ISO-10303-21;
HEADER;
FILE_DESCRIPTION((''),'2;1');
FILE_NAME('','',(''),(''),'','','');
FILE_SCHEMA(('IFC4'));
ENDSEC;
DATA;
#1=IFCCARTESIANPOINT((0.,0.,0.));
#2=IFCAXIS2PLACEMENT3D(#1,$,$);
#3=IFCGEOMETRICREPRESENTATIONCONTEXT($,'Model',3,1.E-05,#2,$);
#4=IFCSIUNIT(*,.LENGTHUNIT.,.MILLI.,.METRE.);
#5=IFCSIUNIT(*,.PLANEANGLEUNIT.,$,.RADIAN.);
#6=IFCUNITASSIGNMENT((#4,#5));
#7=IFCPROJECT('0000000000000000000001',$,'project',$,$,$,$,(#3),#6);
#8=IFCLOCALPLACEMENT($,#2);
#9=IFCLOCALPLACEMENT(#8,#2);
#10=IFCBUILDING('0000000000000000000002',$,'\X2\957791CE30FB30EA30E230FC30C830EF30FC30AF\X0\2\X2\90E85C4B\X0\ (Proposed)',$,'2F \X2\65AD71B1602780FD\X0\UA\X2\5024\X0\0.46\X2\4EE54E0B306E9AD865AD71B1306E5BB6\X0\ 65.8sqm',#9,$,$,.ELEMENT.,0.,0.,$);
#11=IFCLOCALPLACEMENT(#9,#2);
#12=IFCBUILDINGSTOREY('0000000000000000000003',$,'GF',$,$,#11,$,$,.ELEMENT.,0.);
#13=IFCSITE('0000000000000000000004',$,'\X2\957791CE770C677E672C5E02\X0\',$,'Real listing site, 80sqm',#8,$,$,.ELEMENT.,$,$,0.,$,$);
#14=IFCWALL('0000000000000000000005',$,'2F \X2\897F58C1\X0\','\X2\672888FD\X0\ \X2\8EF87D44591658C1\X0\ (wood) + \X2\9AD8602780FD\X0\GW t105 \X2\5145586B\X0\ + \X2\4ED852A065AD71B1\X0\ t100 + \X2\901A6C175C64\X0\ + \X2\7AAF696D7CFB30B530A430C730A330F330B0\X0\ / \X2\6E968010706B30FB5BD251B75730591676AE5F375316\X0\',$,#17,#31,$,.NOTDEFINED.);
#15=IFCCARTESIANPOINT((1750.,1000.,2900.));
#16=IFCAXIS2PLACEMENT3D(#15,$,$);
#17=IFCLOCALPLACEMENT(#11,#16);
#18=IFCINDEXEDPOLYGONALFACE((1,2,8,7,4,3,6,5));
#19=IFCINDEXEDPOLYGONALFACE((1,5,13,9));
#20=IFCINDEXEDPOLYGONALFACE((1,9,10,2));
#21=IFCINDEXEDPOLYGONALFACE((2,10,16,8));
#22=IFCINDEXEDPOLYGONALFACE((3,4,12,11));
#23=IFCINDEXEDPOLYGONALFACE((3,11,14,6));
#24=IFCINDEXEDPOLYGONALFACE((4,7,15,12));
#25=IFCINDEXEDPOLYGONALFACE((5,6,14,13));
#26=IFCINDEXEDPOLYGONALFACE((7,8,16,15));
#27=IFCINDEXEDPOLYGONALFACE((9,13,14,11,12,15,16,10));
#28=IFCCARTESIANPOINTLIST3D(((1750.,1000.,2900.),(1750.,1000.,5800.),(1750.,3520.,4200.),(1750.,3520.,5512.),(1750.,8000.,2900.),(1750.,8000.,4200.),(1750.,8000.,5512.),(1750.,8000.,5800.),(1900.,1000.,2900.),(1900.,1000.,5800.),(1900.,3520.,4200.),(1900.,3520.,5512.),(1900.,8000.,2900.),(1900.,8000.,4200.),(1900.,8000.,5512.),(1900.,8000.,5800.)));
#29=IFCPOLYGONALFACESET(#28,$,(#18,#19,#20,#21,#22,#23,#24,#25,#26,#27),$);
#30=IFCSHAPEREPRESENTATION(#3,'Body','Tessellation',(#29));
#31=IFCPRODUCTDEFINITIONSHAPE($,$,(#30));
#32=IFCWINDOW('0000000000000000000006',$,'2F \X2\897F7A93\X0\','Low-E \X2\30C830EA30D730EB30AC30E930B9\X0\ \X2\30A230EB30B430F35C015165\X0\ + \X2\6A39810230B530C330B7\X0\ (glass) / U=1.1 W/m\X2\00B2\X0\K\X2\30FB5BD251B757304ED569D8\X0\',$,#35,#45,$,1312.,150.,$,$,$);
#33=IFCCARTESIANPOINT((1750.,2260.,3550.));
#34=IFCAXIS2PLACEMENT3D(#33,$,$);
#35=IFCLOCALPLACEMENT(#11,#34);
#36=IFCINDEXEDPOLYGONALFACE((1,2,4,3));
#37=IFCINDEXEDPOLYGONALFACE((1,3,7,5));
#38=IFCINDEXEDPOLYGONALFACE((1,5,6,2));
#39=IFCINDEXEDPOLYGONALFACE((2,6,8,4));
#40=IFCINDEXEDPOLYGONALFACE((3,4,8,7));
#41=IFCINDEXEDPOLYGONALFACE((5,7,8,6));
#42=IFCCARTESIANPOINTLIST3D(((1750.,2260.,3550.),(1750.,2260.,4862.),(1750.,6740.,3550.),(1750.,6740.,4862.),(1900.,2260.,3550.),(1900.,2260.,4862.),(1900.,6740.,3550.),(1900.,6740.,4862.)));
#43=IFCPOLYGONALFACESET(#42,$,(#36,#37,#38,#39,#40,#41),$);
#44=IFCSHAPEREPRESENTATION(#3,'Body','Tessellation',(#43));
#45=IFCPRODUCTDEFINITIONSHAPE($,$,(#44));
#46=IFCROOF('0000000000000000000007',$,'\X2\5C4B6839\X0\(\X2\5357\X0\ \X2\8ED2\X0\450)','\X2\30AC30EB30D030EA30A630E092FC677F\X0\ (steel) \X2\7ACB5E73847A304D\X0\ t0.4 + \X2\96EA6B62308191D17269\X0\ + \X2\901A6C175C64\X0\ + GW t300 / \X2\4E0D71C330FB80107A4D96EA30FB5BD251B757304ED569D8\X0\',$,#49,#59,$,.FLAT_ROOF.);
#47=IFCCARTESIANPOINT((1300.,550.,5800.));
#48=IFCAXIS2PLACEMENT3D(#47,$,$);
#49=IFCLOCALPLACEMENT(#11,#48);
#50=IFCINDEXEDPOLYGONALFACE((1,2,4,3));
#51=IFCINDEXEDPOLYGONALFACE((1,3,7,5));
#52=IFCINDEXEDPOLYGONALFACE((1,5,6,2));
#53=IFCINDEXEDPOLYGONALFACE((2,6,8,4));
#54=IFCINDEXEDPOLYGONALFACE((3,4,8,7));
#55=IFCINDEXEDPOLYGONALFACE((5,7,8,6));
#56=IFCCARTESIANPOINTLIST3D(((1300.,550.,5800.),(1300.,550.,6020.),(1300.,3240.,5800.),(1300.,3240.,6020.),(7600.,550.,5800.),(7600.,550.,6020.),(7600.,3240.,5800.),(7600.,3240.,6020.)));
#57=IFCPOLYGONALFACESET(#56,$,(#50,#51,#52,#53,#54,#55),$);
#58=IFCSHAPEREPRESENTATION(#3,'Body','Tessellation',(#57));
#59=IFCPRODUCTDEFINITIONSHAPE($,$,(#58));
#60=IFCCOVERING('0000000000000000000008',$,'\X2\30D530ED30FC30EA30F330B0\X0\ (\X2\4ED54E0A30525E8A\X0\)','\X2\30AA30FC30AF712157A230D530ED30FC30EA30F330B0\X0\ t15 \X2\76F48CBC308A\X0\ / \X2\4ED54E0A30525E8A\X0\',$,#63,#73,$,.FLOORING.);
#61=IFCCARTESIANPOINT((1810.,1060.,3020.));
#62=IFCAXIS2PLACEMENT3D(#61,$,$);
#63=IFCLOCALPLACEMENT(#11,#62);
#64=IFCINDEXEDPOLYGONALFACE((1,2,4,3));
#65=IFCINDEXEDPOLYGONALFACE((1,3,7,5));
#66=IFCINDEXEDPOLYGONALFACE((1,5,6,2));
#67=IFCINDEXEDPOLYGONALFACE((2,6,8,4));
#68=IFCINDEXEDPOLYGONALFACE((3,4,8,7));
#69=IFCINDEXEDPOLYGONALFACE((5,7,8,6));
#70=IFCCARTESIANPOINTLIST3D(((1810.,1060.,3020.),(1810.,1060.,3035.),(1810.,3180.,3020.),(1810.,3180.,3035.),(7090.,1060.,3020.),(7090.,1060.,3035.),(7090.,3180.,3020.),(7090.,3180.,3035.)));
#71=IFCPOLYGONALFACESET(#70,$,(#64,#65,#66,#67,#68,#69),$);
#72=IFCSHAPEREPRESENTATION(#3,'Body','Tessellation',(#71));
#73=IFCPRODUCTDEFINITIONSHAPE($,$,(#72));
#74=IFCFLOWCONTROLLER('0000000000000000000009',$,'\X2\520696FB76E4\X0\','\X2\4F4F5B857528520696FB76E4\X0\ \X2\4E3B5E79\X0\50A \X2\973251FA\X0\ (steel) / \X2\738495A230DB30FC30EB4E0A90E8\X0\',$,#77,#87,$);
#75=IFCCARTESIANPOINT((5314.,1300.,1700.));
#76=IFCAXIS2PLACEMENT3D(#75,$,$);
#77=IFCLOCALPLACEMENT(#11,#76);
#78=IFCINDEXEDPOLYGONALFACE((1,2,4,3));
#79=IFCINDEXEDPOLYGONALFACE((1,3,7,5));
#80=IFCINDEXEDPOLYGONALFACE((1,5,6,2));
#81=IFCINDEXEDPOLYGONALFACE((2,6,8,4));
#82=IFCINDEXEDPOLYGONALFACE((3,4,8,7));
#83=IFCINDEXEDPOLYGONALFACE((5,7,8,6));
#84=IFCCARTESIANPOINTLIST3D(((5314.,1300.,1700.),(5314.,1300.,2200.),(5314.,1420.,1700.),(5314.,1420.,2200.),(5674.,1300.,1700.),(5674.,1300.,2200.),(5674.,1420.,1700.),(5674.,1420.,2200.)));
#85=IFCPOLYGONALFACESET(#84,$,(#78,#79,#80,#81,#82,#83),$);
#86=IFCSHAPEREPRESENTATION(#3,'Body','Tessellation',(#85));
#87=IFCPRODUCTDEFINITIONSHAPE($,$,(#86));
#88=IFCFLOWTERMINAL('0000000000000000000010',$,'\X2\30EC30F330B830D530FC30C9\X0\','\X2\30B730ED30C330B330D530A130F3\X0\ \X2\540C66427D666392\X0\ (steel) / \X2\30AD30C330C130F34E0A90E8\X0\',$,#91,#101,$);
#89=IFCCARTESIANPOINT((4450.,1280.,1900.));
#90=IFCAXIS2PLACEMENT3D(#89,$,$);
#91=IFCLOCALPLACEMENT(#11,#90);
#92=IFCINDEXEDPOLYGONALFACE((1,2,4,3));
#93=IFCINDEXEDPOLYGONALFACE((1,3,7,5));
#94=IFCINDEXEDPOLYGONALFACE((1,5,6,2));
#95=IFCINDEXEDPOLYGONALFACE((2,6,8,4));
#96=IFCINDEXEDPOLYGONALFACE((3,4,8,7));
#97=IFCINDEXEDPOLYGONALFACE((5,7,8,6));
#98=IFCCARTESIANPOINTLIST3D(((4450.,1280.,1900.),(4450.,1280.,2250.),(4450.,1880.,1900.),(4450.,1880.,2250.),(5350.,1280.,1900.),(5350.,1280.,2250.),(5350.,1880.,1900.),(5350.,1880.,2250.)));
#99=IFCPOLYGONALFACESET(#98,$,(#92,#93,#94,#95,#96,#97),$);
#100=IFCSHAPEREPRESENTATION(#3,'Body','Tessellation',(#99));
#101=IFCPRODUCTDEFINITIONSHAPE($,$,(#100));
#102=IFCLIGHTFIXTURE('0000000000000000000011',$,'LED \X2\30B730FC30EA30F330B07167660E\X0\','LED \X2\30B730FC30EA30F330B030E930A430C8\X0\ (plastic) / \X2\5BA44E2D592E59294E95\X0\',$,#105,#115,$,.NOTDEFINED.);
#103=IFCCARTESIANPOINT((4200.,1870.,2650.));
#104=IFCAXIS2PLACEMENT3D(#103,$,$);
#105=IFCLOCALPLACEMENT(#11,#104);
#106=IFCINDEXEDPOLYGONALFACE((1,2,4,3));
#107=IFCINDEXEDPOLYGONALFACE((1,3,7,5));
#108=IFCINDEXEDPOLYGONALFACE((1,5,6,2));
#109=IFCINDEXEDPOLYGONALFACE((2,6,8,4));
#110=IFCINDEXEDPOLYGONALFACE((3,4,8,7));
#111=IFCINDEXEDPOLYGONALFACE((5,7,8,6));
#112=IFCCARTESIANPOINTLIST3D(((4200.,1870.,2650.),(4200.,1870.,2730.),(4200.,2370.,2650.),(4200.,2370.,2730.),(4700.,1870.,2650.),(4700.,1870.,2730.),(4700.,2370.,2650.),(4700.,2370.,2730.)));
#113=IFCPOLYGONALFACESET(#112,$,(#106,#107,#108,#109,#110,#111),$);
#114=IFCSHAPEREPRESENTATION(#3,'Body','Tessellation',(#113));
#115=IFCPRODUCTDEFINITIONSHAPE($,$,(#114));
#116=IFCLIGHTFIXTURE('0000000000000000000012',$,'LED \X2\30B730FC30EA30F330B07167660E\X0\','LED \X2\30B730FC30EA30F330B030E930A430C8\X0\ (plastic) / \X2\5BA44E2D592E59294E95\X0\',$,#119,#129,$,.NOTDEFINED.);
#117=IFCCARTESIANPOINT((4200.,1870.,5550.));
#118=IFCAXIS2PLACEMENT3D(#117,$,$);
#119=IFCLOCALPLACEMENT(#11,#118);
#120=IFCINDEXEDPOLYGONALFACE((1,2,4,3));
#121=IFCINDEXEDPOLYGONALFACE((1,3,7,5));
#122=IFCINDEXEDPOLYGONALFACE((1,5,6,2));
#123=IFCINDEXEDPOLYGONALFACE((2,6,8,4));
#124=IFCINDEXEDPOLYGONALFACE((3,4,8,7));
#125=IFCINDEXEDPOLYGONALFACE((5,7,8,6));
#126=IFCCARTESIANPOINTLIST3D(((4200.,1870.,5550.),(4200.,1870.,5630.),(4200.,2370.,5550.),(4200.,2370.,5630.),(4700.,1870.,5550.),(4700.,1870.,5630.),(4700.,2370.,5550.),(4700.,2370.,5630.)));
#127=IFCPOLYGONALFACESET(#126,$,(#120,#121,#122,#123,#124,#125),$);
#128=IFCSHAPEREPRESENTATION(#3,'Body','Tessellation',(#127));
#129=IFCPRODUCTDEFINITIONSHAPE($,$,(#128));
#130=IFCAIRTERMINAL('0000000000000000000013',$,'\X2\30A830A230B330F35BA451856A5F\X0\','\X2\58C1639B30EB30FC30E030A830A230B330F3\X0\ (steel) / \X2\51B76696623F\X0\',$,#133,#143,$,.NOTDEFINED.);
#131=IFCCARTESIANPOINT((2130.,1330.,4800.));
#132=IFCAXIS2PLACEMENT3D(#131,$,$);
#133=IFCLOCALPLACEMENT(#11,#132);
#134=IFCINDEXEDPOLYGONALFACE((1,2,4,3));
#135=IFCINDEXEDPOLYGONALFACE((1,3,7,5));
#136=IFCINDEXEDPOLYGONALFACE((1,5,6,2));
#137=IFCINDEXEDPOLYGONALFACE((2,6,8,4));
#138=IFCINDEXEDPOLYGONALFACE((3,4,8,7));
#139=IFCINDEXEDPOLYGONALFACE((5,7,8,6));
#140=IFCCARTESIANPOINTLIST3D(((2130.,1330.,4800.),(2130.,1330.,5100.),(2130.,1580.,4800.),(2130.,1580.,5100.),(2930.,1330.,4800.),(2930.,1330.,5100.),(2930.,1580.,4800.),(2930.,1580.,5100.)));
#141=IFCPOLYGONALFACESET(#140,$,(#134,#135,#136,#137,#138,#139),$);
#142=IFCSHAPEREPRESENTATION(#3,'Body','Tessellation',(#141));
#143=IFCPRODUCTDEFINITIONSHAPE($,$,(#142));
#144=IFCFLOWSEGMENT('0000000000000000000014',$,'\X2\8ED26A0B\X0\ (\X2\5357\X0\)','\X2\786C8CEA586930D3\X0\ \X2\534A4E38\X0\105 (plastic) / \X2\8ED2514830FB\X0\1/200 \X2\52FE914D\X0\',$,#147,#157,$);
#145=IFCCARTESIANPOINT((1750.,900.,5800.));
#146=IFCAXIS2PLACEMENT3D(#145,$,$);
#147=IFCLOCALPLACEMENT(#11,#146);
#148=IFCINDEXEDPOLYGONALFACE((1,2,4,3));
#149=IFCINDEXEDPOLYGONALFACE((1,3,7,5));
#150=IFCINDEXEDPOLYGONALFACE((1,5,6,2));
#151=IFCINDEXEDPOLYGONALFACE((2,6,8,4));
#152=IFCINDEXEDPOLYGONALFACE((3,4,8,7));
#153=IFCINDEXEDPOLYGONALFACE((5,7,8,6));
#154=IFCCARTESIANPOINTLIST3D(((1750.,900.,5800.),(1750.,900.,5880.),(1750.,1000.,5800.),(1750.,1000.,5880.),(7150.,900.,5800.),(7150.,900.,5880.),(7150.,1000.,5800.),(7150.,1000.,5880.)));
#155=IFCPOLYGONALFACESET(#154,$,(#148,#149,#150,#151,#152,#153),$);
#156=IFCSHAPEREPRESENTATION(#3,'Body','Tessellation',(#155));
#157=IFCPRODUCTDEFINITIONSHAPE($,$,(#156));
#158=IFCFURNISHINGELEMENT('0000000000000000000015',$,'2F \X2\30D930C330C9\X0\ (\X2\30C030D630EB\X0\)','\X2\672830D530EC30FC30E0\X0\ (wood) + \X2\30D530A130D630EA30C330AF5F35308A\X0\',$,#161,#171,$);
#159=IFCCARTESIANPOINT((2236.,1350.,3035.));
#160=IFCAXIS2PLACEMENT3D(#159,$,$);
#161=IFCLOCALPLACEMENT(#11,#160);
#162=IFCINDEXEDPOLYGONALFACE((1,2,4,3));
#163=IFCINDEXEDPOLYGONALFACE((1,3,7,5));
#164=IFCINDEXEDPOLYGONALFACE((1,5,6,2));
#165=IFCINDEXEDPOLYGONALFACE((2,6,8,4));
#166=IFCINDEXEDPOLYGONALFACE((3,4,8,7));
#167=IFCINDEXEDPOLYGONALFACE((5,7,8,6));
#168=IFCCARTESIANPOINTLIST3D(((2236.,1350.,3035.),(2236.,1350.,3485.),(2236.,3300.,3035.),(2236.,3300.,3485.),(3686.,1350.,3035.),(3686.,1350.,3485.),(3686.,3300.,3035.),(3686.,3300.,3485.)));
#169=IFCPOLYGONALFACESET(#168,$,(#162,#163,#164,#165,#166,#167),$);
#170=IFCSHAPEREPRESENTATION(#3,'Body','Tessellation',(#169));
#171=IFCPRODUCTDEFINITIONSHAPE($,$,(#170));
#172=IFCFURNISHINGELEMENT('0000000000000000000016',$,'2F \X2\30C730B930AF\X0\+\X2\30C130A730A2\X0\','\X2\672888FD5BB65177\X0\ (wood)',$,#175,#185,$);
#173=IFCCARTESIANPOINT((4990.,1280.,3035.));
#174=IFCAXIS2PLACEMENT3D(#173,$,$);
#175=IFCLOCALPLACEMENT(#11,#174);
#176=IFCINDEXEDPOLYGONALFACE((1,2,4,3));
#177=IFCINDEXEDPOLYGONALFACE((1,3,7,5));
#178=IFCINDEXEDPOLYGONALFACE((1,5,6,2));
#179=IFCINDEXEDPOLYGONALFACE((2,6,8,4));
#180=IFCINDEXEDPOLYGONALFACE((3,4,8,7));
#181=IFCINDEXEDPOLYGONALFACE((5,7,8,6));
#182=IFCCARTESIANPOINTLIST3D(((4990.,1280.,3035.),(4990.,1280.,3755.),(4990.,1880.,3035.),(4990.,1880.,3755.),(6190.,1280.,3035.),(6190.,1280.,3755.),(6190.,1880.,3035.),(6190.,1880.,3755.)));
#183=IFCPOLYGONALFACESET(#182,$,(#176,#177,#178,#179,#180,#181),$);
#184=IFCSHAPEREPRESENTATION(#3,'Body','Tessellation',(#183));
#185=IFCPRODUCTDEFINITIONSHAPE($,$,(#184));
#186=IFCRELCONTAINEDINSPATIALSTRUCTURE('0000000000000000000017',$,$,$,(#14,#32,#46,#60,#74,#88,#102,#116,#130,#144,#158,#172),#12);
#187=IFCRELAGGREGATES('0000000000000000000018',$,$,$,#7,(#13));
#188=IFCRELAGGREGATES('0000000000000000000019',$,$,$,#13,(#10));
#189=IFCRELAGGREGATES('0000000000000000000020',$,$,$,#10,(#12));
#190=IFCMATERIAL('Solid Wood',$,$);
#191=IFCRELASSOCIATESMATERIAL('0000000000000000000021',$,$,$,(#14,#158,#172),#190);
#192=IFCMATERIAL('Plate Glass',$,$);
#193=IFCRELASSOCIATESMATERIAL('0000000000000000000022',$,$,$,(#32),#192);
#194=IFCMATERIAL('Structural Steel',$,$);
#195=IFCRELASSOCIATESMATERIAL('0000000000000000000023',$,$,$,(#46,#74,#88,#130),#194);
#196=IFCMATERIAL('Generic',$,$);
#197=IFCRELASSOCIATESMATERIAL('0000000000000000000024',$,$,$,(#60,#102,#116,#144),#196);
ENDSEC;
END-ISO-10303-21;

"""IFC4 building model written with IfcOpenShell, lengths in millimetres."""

from ifc_helpers import new_model, si_unit, frame, frame_2d, origin, place, context, project, spatial, rectangle, extrude, material, element, fill, save


model = new_model("IFC4")

# Units and contexts
model_context = context("Model", 3, precision=1e-05, world=origin())
ifc_project = project(units=[si_unit("LENGTHUNIT", "METRE", prefix="MILLI"), si_unit("PLANEANGLEUNIT", "RADIAN")], contexts=[model_context])

# Site, building, storey
site_placement = place(None, origin())
site = spatial("IfcSite", under=ifc_project, at=site_placement, Name="長野県松本市", ObjectType="Real listing site, 80sqm", CompositionType="ELEMENT", RefElevation=0.0)
building_placement = place(site_placement, origin())
building = spatial("IfcBuilding", under=site, at=building_placement, Name="長野・リモートワーク2部屋 (Proposed)", ObjectType="2F 断熱性能UA値0.46以下の高断熱の家 65.8sqm", CompositionType="ELEMENT", ElevationOfRefHeight=0.0, ElevationOfTerrain=0.0)
storey_placement = place(building_placement, origin())
storey = spatial("IfcBuildingStorey", under=building, at=storey_placement, Name="GF", CompositionType="ELEMENT", Elevation=0.0)

# Shared definitions
ifc_material_1 = material(Name="Solid Wood")

# Wall, opening, window
ifc_material_2 = material(Name="Plate Glass")
wall_1_placement = place(storey_placement, frame((1750.0, 1000.0, 2900.0)))
wall_1 = element("IfcWall", 1, at=wall_1_placement, inside=storey, material=ifc_material_1, Name="2F 西壁", Description="木製 軸組外壁 (wood) + 高性能GW t105 充填 + 付加断熱 t100 + 通気層 + 窯業系サイディング / 準耐火・寒冷地外皮強化", PredefinedType="NOTDEFINED", context=model_context, shape_type="SweptSolid", body=[
    extrude(rectangle(XDim=150.0, YDim=7000.0, at=frame_2d((75.0, 3500.0))), frame((1750.0, 1000.0, 2900.0)), (0.0, 0.0, 1.0), 2900.0),
])
opening_1_placement = place(storey_placement, frame((1750.0, 2260.0, 3550.0)))
opening_1 = element("IfcOpeningElement", 2, at=opening_1_placement, cuts=wall_1, PredefinedType="NOTDEFINED", context=model_context, shape_type="SweptSolid", body=[
    extrude(rectangle(XDim=150.0, YDim=4480.0, at=frame_2d((75.0, 2240.0))), frame((1750.0, 2260.0, 3550.0)), (0.0, 0.0, 1.0), 1312.0),
])
window_1_placement = place(storey_placement, frame((1750.0, 2260.0, 3550.0)))
window_1 = element("IfcWindow", 3, at=window_1_placement, inside=storey, material=ifc_material_2, Name="2F 西窓", Description="Low-E トリプルガラス アルゴン封入 + 樹脂サッシ (glass) / U=1.1 W/m²K・寒冷地仕様", OverallHeight=1312.0, OverallWidth=150.0, context=model_context, shape_type="SweptSolid", body=[
    extrude(rectangle(XDim=150.0, YDim=4480.0, at=frame_2d((75.0, 2240.0))), frame((1750.0, 2260.0, 3550.0)), (0.0, 0.0, 1.0), 1312.0),
])
fill(opening_1, window_1)

# Roof
ifc_material_3 = material(Name="Structural Steel")
for number, where, name in (
    (4, (1300.0, 550.0, 5800.0), "屋根(南 軒450)"),
):
    element("IfcRoof", number, at=place(storey_placement, frame(where)), inside=storey, material=ifc_material_3, Name=name, Description="ガルバリウム鋼板 (steel) 立平葺き t0.4 + 雪止め金物 + 通気層 + GW t300 / 不燃・耐積雪・寒冷地仕様", PredefinedType="FLAT_ROOF", context=model_context, shape_type="SweptSolid", body=[
        extrude(rectangle(XDim=6300.0, YDim=2690.0, at=frame_2d((3150.0, 1345.0))), frame((1300.0, 550.0, 5800.0)), (0.0, 0.0, 1.0), 220.0),
    ])

# Covering
ifc_material_4 = material(Name="Generic")
covering_placement = place(storey_placement, frame((1810.0, 1060.0, 3020.0)))
element("IfcCovering", 5, at=covering_placement, inside=storey, material=ifc_material_4, Name="フローリング (仕上げ床)", Description="オーク無垢フローリング t15 直貼り / 仕上げ床", PredefinedType="FLOORING", context=model_context, shape_type="SweptSolid", body=[
    extrude(rectangle(XDim=5280.0, YDim=2120.0, at=frame_2d((2640.0, 1060.0))), frame((1810.0, 1060.0, 3020.0)), (0.0, 0.0, 1.0), 15.0),
])

# Flow controller
flow_controller_placement = place(storey_placement, frame((5314.0, 1300.0, 1700.0)))
element("IfcFlowController", 6, at=flow_controller_placement, inside=storey, material=ifc_material_3, Name="分電盤", Description="住宅用分電盤 主幹50A 露出 (steel) / 玄関ホール上部", context=model_context, shape_type="SweptSolid", body=[
    extrude(rectangle(XDim=360.0, YDim=120.0, at=frame_2d((180.0, 60.0))), frame((5314.0, 1300.0, 1700.0)), (0.0, 0.0, 1.0), 500.0),
])

# Flow terminal
flow_terminal_placement = place(storey_placement, frame((4450.0, 1280.0, 1900.0)))
element("IfcFlowTerminal", 7, at=flow_terminal_placement, inside=storey, material=ifc_material_3, Name="レンジフード", Description="シロッコファン 同時給排 (steel) / キッチン上部", context=model_context, shape_type="SweptSolid", body=[
    extrude(rectangle(XDim=900.0, YDim=600.0, at=frame_2d((450.0, 300.0))), frame((4450.0, 1280.0, 1900.0)), (0.0, 0.0, 1.0), 350.0),
])

# Light fixtures
light_fixture_1_placement = place(storey_placement, frame((4200.0, 1870.0, 2650.0)))
element("IfcLightFixture", 8, at=light_fixture_1_placement, inside=storey, material=ifc_material_4, Name="LED シーリング照明", Description="LED シーリングライト (plastic) / 室中央天井", PredefinedType="NOTDEFINED", context=model_context, shape_type="SweptSolid", body=[
    extrude(rectangle(XDim=500.0, YDim=500.0, at=frame_2d((250.0, 250.0))), frame((4200.0, 1870.0, 2650.0)), (0.0, 0.0, 1.0), 80.0),
])
light_fixture_2_placement = place(storey_placement, frame((4200.0, 1870.0, 5550.0)))
element("IfcLightFixture", 9, at=light_fixture_2_placement, inside=storey, material=ifc_material_4, Name="LED シーリング照明", Description="LED シーリングライト (plastic) / 室中央天井", PredefinedType="NOTDEFINED", context=model_context, shape_type="SweptSolid", body=[
    extrude(rectangle(XDim=500.0, YDim=500.0, at=frame_2d((250.0, 250.0))), frame((4200.0, 1870.0, 5550.0)), (0.0, 0.0, 1.0), 80.0),
])

# Air terminal
air_terminal_placement = place(storey_placement, frame((2130.0, 1330.0, 4800.0)))
element("IfcAirTerminal", 10, at=air_terminal_placement, inside=storey, material=ifc_material_3, Name="エアコン室内機", Description="壁掛ルームエアコン (steel) / 冷暖房", PredefinedType="NOTDEFINED", context=model_context, shape_type="SweptSolid", body=[
    extrude(rectangle(XDim=800.0, YDim=250.0, at=frame_2d((400.0, 125.0))), frame((2130.0, 1330.0, 4800.0)), (0.0, 0.0, 1.0), 300.0),
])

# Flow segment
flow_segment_placement = place(storey_placement, frame((1750.0, 900.0, 5800.0)))
element("IfcFlowSegment", 11, at=flow_segment_placement, inside=storey, material=ifc_material_4, Name="軒樋 (南)", Description="硬質塩ビ 半丸105 (plastic) / 軒先・1/200 勾配", context=model_context, shape_type="SweptSolid", body=[
    extrude(rectangle(XDim=5400.0, YDim=100.0, at=frame_2d((2700.0, 50.0))), frame((1750.0, 900.0, 5800.0)), (0.0, 0.0, 1.0), 80.0),
])

# Furnishing elements
furnishing_1_placement = place(storey_placement, frame((2236.0, 1350.0, 3035.0)))
element("IfcFurnishingElement", 12, at=furnishing_1_placement, inside=storey, material=ifc_material_1, Name="2F ベッド (ダブル)", Description="木フレーム (wood) + ファブリック張り", context=model_context, shape_type="SweptSolid", body=[
    extrude(rectangle(XDim=1450.0, YDim=1950.0, at=frame_2d((725.0, 975.0))), frame((2236.0, 1350.0, 3035.0)), (0.0, 0.0, 1.0), 450.0),
])
furnishing_2_placement = place(storey_placement, frame((4990.0, 1280.0, 3035.0)))
element("IfcFurnishingElement", 13, at=furnishing_2_placement, inside=storey, material=ifc_material_1, Name="2F デスク+チェア", Description="木製家具 (wood)", context=model_context, shape_type="SweptSolid", body=[
    extrude(rectangle(XDim=1200.0, YDim=600.0, at=frame_2d((600.0, 300.0))), frame((4990.0, 1280.0, 3035.0)), (0.0, 0.0, 1.0), 720.0),
])

save(model, "model.ifc")
